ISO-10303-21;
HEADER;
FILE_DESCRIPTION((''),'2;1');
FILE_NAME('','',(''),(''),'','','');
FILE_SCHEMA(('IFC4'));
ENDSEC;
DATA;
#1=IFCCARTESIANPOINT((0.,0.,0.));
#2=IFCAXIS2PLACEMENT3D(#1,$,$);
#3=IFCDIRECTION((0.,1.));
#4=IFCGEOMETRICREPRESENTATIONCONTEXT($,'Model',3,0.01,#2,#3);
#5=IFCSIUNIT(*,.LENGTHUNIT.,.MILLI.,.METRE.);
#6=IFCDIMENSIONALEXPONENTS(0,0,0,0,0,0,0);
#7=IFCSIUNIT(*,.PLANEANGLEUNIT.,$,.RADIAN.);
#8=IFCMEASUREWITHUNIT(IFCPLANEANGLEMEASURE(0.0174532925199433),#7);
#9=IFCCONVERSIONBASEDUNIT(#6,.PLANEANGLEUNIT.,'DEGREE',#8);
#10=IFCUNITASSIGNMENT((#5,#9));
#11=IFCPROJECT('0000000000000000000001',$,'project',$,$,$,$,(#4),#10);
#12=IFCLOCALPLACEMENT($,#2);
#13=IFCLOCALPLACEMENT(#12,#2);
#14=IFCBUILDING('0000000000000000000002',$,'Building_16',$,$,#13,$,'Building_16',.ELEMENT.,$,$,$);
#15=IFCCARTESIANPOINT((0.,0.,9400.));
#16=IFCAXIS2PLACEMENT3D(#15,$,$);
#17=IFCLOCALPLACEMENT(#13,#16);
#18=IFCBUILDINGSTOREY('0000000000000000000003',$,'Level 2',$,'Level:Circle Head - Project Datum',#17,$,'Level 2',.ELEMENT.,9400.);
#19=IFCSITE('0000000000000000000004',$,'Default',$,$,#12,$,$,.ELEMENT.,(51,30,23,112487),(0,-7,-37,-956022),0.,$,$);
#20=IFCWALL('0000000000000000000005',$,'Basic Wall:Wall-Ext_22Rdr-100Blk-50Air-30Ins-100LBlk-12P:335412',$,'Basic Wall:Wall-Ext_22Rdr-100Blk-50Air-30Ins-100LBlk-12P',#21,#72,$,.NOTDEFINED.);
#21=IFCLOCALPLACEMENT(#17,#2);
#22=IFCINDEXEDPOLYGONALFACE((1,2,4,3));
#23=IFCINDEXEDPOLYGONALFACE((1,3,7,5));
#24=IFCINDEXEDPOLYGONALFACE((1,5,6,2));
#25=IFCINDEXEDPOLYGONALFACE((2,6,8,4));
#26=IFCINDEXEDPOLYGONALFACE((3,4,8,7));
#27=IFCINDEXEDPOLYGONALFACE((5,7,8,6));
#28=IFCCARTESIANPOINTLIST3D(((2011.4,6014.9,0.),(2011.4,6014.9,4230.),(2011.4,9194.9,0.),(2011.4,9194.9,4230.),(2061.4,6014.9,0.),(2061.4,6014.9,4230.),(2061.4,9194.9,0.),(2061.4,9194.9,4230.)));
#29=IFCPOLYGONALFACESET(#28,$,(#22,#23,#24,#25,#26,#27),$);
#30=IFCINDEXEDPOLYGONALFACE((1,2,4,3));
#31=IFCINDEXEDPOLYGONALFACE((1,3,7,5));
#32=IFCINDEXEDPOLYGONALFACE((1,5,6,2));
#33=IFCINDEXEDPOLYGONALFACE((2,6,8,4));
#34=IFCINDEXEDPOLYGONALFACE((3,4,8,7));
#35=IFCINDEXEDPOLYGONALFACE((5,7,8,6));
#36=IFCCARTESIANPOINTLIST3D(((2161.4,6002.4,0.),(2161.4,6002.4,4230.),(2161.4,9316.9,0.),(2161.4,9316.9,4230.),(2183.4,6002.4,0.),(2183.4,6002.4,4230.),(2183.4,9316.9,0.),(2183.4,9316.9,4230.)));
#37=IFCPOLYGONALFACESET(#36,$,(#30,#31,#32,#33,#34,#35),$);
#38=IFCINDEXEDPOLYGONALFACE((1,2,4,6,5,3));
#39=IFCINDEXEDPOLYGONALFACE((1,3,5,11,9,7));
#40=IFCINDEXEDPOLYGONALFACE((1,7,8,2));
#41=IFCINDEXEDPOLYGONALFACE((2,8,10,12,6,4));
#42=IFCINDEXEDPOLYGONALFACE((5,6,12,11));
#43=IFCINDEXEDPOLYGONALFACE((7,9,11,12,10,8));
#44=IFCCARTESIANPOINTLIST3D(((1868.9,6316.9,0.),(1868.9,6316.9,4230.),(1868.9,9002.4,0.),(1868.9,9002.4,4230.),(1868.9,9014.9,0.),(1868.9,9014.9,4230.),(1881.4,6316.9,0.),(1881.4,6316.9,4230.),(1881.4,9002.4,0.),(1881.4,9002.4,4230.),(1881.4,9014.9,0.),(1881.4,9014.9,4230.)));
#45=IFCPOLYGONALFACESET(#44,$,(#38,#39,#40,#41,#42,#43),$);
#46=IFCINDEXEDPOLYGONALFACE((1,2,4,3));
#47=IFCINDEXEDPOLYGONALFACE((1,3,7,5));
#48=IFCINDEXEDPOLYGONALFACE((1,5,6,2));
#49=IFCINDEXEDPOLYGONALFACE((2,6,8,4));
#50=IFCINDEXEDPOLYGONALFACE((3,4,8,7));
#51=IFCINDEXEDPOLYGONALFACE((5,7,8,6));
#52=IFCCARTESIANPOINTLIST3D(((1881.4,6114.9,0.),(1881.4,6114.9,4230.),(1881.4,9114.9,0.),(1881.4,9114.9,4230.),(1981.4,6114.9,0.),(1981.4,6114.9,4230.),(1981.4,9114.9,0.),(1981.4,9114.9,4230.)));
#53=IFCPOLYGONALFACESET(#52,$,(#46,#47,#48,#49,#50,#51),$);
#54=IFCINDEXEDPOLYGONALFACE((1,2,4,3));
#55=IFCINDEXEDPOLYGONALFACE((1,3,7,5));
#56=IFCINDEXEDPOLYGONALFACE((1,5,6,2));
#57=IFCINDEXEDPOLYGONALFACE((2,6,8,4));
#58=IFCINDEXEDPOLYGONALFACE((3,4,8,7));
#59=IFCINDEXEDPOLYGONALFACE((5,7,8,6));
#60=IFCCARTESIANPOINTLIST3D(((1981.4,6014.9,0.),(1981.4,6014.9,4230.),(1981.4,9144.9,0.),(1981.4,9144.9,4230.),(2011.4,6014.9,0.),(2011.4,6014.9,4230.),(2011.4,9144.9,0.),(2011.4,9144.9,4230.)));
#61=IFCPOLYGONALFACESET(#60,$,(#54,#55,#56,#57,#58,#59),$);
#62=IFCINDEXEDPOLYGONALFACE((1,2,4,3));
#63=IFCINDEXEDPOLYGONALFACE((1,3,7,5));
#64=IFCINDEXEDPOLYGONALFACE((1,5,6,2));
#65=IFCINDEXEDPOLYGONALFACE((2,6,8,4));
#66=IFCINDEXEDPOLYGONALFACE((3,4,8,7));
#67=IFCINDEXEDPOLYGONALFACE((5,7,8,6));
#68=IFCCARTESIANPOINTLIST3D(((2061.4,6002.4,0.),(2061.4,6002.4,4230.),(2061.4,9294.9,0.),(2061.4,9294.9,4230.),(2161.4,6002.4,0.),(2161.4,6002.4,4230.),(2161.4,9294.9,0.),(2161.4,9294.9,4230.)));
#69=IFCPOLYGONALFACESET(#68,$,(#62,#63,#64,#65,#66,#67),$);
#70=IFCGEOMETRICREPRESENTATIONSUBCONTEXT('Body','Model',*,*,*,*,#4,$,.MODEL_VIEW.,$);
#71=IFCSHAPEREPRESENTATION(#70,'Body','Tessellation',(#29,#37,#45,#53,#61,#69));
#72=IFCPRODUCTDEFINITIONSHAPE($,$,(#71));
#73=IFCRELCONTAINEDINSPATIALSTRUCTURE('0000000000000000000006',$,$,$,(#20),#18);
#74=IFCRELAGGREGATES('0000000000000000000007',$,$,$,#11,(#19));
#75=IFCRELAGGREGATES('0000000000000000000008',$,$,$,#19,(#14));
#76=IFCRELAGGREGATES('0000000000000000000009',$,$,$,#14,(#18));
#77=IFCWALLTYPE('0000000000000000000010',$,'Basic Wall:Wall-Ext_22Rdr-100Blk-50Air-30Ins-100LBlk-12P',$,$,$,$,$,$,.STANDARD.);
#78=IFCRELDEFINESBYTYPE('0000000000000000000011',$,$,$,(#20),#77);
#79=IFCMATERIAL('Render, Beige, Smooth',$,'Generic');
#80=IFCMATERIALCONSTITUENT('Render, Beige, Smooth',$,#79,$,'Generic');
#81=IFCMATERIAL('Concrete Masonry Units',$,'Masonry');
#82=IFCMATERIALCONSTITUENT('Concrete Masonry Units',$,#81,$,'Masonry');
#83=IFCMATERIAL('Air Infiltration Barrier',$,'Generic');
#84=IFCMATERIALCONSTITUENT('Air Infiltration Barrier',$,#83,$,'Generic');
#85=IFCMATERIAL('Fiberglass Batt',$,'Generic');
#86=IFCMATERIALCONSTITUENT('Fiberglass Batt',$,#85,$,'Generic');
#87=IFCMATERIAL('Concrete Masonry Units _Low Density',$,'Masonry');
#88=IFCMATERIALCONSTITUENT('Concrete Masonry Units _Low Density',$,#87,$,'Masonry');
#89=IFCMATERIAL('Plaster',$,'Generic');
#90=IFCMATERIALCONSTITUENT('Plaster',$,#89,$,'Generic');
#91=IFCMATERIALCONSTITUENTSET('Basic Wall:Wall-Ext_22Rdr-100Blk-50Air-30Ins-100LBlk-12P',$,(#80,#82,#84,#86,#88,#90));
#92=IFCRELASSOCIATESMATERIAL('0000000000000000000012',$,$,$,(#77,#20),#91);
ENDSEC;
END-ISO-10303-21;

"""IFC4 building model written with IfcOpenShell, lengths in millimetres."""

from ifc_helpers import new_model, entity, si_unit, converted_unit, direction, frame, origin, place, context, subcontext, project, spatial, indexed_curve, outline, extrude, material, constituent, constituent_set, type_object, element, save


model = new_model("IFC4")

# Units and contexts
model_context = context("Model", 3, precision=0.01, world=origin(), true_north=direction((0.0, 1.0)))
body_context = subcontext(model_context, "Body", "Model", "MODEL_VIEW")
ifc_project = project(units=[si_unit("LENGTHUNIT", "METRE", prefix="MILLI"), converted_unit("PLANEANGLEUNIT", "DEGREE", entity("IfcPlaneAngleMeasure", 0.0174532925199433), si_unit("PLANEANGLEUNIT", "RADIAN"), dimensions=[0, 0, 0, 0, 0, 0, 0])], contexts=[model_context])

# Site, building, storey
site_placement = place(None, origin())
site = spatial("IfcSite", under=ifc_project, at=site_placement, Name="Default", CompositionType="ELEMENT", RefLatitude=(51, 30, 23, 112487), RefLongitude=(0, -7, -37, -956022), RefElevation=0.0)
building_placement = place(site_placement, origin())
building = spatial("IfcBuilding", under=site, at=building_placement, Name="Building_16", LongName="Building_16", CompositionType="ELEMENT")
storey_placement = place(building_placement, frame((0.0, 0.0, 9400.0)))
storey = spatial("IfcBuildingStorey", under=building, at=storey_placement, Name="Level 2", ObjectType="Level:Circle Head - Project Datum", LongName="Level 2", CompositionType="ELEMENT", Elevation=9400.0)

# Shared definitions
ifc_material_1 = material(Name="Render, Beige, Smooth", Category="Generic")
ifc_constituent_1 = constituent(ifc_material_1, Name="Render, Beige, Smooth", Category="Generic")
ifc_material_2 = material(Name="Concrete Masonry Units", Category="Masonry")
ifc_constituent_2 = constituent(ifc_material_2, Name="Concrete Masonry Units", Category="Masonry")
ifc_material_3 = material(Name="Air Infiltration Barrier", Category="Generic")
ifc_constituent_3 = constituent(ifc_material_3, Name="Air Infiltration Barrier", Category="Generic")
ifc_material_4 = material(Name="Fiberglass Batt", Category="Generic")
ifc_constituent_4 = constituent(ifc_material_4, Name="Fiberglass Batt", Category="Generic")
ifc_material_5 = material(Name="Concrete Masonry Units _Low Density", Category="Masonry")
ifc_constituent_5 = constituent(ifc_material_5, Name="Concrete Masonry Units _Low Density", Category="Masonry")
ifc_material_6 = material(Name="Plaster", Category="Generic")
ifc_constituent_6 = constituent(ifc_material_6, Name="Plaster", Category="Generic")
ifc_constituent_set_1 = constituent_set(constituents=[ifc_constituent_1, ifc_constituent_2, ifc_constituent_3, ifc_constituent_4, ifc_constituent_5, ifc_constituent_6], Name="Basic Wall:Wall-Ext_22Rdr-100Blk-50Air-30Ins-100LBlk-12P")
wall_type_1 = type_object("IfcWallType", Name="Basic Wall:Wall-Ext_22Rdr-100Blk-50Air-30Ins-100LBlk-12P", PredefinedType="STANDARD", material=ifc_constituent_set_1)

# Wall
wall_1_placement = place(storey_placement, frame((2026.1, 9316.9, 0.0), z_axis=(0.0, 0.0, 1.0), x_axis=(0.0, -1.0, 0.0)))
element("IfcWall", 1, at=wall_1_placement, inside=storey, type_object=wall_type_1, material=ifc_constituent_set_1, Name="Basic Wall:Wall-Ext_22Rdr-100Blk-50Air-30Ins-100LBlk-12P:335412", ObjectType="Basic Wall:Wall-Ext_22Rdr-100Blk-50Air-30Ins-100LBlk-12P", PredefinedType="NOTDEFINED", context=body_context, shape_type="SweptSolid", body=[
    extrude(outline(indexed_curve([(-2115.0, -1590.0), (2115.0, -1590.0), (2115.0, 1590.0), (-2115.0, 1590.0), (-2115.0, -1590.0)], self_intersect=False)), frame((1712.0, -14.8, 2115.0), z_axis=(0.0, 1.0, 0.0), x_axis=(0.0, 0.0, 1.0)), (0.0, 0.0, 1.0), 50.0),
    extrude(outline(indexed_curve([(-2115.0, -1657.3), (2115.0, -1657.3), (2115.0, 1657.3), (-2115.0, 1657.3), (-2115.0, -1657.3)], self_intersect=False)), frame((1657.3, 135.2, 2115.0), z_axis=(0.0, 1.0, 0.0), x_axis=(0.0, 0.0, 1.0)), (0.0, 0.0, 1.0), 22.0),
    extrude(outline(indexed_curve([(-2115.0, -903.5), (2115.0, -903.5), (2115.0, -891.0), (2115.0, 1794.5), (-2115.0, 1794.5), (-2115.0, -891.0), (-2115.0, -903.5)], self_intersect=False)), frame((1205.5, -157.2, 2115.0), z_axis=(0.0, 1.0, 0.0), x_axis=(0.0, 0.0, 1.0)), (0.0, 0.0, 1.0), 12.5),
    extrude(outline(indexed_curve([(-2115.0, -1500.0), (2115.0, -1500.0), (2115.0, 1500.0), (-2115.0, 1500.0), (-2115.0, -1500.0)], self_intersect=False)), frame((1702.0, -144.8, 2115.0), z_axis=(0.0, 1.0, 0.0), x_axis=(0.0, 0.0, 1.0)), (0.0, 0.0, 1.0), 100.0),
    extrude(outline(indexed_curve([(-2115.0, -1565.0), (2115.0, -1565.0), (2115.0, 1565.0), (-2115.0, 1565.0), (-2115.0, -1565.0)], self_intersect=False)), frame((1737.0, -44.8, 2115.0), z_axis=(0.0, 1.0, 0.0), x_axis=(0.0, 0.0, 1.0)), (0.0, 0.0, 1.0), 30.0),
    extrude(outline(indexed_curve([(-2115.0, -1646.2), (2115.0, -1646.2), (2115.0, 1646.3), (-2115.0, 1646.3), (-2115.0, -1646.2)], self_intersect=False)), frame((1668.3, 35.3, 2115.0), z_axis=(0.0, 1.0, 0.0), x_axis=(0.0, 0.0, 1.0)), (0.0, 0.0, 1.0), 100.0),
])

save(model, "model.ifc")
